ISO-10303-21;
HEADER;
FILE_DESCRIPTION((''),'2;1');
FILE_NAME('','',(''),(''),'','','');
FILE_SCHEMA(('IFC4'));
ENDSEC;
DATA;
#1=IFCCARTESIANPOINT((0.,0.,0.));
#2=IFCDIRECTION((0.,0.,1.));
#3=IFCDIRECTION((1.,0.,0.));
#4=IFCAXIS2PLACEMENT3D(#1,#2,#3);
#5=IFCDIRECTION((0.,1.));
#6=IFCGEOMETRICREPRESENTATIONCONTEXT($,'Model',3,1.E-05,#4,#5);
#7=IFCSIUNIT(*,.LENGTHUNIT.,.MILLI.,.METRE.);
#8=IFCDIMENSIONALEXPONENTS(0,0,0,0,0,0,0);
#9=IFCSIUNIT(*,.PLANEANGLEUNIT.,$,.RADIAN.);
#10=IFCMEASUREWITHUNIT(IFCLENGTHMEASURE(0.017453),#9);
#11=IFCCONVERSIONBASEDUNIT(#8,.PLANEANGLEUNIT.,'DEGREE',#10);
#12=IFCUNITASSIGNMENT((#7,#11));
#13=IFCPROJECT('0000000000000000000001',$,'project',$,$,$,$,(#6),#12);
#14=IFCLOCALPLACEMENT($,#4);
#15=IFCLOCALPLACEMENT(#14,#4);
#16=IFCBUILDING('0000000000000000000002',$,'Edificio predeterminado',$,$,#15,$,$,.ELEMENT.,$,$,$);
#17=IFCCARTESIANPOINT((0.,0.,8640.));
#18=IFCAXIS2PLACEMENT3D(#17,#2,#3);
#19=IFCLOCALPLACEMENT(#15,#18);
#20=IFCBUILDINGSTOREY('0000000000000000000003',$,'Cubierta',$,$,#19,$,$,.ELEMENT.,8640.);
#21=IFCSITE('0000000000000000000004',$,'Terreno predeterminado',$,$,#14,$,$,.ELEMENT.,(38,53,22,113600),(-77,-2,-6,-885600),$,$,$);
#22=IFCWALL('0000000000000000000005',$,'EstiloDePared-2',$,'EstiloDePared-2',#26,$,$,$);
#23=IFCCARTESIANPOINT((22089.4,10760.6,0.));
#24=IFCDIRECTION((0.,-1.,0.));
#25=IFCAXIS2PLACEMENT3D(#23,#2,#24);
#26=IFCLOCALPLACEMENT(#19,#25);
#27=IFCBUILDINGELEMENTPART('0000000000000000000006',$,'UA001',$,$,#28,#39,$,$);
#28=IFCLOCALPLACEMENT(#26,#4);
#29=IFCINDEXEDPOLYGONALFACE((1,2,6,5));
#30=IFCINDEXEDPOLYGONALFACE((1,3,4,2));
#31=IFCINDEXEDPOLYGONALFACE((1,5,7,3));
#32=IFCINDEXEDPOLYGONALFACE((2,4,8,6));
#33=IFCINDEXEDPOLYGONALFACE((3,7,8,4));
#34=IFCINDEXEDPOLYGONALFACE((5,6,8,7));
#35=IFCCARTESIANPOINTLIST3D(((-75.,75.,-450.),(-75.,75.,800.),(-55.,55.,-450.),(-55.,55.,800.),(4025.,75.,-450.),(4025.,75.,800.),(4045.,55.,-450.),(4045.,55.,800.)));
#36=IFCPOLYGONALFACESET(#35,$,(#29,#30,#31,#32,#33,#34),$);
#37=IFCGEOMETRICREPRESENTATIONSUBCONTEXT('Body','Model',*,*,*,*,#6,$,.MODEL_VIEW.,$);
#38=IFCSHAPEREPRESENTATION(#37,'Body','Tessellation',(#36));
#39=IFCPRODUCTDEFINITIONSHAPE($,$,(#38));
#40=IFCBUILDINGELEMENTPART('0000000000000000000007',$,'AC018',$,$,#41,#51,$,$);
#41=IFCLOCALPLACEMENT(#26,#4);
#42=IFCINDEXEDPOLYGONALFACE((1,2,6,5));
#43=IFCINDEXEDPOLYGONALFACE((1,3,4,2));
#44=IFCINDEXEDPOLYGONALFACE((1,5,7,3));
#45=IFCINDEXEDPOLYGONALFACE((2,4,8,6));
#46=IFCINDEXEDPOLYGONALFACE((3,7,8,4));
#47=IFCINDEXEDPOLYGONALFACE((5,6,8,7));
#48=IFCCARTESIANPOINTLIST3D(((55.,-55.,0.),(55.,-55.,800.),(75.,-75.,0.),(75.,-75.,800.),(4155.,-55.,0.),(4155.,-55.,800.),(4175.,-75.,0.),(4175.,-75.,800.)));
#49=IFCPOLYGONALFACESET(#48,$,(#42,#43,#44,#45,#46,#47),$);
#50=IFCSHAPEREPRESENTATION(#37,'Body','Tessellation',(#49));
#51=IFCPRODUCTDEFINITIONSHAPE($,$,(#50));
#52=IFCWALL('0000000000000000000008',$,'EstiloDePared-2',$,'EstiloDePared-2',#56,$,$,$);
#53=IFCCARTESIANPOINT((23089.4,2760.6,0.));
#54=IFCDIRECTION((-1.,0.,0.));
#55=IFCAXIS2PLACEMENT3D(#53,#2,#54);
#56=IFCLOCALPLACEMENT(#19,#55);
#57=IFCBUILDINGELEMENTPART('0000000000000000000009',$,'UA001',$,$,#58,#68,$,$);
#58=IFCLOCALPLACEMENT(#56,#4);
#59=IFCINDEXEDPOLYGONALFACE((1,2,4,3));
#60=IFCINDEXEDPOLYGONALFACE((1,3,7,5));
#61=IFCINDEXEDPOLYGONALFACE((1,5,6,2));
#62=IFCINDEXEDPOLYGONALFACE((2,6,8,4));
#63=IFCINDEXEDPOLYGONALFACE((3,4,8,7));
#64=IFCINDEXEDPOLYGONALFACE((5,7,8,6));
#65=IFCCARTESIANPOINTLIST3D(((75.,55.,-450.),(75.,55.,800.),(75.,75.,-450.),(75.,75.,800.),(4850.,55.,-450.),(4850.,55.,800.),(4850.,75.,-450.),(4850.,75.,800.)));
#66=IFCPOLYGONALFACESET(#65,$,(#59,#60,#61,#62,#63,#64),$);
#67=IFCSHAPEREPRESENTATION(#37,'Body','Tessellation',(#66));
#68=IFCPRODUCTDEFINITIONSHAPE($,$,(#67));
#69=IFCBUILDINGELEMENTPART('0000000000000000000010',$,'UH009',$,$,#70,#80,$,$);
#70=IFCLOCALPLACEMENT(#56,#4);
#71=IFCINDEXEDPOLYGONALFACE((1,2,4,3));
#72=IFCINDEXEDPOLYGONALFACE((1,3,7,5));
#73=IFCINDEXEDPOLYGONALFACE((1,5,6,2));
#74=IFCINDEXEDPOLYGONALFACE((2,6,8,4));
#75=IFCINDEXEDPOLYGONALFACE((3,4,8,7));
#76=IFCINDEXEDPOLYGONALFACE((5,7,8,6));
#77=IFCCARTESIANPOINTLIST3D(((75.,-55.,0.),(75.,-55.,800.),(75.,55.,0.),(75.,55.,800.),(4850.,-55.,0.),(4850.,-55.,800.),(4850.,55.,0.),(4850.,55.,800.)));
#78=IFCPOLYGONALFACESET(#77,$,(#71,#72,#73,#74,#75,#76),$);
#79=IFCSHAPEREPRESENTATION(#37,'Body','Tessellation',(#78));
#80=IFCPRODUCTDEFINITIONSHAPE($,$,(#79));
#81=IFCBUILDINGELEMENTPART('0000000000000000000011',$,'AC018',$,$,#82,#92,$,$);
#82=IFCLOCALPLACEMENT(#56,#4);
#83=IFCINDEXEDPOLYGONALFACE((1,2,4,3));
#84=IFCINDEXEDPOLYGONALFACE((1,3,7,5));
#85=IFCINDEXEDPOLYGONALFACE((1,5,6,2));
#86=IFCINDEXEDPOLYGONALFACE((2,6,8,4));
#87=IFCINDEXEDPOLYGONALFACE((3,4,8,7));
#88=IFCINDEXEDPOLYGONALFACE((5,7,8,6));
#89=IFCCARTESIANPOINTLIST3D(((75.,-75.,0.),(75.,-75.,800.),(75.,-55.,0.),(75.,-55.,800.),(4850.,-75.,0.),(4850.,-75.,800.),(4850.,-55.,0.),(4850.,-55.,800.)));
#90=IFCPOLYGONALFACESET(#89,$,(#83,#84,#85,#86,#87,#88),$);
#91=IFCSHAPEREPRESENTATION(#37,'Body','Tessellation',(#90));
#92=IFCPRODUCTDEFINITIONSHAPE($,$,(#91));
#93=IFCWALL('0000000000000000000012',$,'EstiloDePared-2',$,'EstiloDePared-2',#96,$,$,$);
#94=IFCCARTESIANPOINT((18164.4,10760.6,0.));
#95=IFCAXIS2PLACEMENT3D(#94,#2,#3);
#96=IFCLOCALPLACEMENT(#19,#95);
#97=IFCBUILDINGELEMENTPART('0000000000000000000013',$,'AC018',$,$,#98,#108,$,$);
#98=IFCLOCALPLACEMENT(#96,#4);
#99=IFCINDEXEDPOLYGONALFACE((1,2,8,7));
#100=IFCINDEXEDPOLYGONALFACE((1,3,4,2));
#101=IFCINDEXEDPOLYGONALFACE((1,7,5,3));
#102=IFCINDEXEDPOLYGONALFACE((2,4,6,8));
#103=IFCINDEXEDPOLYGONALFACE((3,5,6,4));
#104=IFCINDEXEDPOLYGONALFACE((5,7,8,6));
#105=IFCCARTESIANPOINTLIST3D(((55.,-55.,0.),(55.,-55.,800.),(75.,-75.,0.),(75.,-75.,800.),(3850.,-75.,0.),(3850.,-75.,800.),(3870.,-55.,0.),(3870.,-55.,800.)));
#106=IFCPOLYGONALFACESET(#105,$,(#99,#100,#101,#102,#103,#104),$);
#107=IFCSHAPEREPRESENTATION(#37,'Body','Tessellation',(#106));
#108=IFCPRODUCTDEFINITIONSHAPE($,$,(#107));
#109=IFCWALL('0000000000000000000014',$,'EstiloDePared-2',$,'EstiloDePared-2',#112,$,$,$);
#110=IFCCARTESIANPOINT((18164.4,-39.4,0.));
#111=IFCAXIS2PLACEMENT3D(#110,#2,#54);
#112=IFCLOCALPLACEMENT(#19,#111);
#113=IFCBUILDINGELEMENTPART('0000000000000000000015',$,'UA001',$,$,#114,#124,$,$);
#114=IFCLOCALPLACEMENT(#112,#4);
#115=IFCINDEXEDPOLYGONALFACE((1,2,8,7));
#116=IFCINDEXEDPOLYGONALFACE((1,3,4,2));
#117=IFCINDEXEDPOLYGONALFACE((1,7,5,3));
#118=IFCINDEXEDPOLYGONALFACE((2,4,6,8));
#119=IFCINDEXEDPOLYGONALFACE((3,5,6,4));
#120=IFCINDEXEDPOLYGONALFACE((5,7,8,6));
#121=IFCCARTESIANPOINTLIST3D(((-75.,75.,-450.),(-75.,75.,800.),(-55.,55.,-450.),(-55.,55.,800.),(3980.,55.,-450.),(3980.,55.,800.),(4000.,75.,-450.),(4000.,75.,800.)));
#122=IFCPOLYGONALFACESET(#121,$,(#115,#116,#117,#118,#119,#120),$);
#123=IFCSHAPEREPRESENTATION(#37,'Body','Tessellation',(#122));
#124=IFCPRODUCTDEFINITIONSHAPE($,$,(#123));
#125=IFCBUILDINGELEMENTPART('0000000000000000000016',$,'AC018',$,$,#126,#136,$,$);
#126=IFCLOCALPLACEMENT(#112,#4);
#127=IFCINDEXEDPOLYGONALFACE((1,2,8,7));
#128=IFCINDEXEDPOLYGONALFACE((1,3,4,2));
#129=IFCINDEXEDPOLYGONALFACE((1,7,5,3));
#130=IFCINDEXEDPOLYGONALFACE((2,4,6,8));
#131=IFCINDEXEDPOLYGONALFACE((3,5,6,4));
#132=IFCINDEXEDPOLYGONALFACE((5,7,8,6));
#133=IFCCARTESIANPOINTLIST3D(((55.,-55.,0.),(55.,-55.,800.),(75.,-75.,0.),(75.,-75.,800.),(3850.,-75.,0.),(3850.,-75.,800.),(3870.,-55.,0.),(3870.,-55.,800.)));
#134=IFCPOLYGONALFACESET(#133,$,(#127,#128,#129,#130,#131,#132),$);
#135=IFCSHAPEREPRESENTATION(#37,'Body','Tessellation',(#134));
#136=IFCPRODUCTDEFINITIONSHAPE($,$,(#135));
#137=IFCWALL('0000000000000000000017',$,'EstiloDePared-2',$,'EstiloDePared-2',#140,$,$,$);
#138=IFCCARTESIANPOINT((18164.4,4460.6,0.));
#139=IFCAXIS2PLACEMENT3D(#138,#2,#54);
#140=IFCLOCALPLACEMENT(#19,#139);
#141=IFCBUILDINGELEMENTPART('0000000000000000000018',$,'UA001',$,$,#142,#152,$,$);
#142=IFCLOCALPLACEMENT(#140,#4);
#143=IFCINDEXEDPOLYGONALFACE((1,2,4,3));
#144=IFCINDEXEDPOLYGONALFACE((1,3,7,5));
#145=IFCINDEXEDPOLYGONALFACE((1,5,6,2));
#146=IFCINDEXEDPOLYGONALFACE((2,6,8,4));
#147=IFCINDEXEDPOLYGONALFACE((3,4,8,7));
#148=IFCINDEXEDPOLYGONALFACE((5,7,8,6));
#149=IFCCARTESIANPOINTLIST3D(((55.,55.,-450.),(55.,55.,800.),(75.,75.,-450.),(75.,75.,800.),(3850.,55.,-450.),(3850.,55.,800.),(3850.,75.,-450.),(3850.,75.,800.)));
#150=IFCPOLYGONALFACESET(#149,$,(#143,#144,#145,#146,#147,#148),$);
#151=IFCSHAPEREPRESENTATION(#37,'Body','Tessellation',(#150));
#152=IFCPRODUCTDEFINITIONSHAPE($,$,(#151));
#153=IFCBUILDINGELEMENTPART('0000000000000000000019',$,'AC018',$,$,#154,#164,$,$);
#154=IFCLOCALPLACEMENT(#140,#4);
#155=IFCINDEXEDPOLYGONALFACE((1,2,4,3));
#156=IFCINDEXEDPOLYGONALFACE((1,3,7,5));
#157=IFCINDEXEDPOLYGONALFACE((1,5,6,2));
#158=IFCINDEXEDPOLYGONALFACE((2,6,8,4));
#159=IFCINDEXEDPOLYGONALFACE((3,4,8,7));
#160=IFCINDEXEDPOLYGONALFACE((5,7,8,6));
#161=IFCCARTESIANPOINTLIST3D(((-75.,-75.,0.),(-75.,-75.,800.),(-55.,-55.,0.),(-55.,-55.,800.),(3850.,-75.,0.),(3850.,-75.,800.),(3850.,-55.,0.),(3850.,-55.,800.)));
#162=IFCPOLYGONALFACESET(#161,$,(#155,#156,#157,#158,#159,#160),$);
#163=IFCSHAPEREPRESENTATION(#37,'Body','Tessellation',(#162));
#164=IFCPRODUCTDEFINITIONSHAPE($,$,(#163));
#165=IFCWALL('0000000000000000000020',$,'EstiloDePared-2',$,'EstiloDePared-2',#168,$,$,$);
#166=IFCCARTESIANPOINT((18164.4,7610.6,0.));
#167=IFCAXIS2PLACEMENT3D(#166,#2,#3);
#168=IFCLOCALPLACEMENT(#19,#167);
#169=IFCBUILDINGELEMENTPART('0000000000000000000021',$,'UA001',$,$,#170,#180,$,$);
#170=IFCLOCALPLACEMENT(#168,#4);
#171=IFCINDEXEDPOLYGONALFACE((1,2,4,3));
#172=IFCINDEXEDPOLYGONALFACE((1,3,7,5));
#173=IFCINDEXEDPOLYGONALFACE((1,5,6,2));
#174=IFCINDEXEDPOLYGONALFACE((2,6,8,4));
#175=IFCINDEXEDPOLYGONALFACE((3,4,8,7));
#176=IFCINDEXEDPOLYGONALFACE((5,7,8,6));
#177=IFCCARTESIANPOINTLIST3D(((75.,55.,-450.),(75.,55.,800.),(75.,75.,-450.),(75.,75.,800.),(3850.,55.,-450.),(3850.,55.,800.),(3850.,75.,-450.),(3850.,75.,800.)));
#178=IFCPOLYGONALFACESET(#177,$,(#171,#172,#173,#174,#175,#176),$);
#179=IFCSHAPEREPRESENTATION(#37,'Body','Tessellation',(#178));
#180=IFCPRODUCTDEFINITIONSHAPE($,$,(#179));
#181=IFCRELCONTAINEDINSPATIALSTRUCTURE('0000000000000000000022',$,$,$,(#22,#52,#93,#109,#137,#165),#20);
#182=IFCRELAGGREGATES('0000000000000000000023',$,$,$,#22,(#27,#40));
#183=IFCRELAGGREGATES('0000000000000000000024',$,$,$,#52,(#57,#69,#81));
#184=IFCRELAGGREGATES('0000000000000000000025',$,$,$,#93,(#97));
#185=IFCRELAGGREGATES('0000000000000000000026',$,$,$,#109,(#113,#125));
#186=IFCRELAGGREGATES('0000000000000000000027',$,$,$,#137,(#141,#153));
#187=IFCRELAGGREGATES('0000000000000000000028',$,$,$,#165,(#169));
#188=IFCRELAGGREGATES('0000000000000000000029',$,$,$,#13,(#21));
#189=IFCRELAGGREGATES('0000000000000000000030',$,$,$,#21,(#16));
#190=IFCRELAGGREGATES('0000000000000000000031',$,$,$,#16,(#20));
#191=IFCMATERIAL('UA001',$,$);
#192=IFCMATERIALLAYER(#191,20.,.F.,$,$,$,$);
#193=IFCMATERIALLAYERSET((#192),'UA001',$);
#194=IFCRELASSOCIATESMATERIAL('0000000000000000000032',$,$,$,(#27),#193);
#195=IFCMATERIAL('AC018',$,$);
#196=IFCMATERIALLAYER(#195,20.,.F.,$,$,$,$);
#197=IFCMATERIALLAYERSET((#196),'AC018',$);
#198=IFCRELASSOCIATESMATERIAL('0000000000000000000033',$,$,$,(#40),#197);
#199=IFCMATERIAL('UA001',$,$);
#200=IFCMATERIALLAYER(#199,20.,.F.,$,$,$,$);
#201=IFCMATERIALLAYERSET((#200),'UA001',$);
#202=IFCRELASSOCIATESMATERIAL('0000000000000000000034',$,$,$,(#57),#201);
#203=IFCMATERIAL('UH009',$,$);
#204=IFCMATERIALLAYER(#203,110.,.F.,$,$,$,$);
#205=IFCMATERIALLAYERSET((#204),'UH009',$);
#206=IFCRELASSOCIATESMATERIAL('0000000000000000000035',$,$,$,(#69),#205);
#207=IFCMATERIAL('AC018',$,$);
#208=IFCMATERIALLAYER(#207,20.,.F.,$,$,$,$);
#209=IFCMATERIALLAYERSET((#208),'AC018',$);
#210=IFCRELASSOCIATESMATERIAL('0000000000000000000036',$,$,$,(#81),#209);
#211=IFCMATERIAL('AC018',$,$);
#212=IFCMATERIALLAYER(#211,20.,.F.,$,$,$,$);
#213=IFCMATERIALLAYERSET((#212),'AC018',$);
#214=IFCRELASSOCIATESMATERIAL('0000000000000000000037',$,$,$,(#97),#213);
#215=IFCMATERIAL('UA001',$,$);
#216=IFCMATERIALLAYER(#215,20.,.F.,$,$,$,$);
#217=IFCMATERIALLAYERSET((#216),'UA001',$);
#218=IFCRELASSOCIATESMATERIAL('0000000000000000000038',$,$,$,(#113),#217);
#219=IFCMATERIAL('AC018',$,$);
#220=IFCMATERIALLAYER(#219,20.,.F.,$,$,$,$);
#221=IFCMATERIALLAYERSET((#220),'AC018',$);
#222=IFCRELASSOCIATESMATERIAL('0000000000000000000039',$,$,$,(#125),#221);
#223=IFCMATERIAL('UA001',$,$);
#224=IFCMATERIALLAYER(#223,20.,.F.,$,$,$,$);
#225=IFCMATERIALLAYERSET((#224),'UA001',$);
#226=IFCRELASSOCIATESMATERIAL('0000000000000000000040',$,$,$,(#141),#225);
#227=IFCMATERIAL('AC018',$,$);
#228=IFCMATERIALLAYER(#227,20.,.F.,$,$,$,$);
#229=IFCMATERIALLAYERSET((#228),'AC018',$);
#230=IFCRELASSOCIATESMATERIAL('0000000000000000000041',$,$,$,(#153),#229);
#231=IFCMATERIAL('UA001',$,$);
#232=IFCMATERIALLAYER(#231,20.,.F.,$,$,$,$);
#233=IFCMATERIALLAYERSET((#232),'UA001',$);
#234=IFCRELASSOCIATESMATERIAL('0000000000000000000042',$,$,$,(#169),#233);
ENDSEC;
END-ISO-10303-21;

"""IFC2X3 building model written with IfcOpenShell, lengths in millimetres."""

from ifc_helpers import new_model, entity, si_unit, converted_unit, direction, frame, origin_with_axes, place, context, subcontext, project, spatial, polyline, outline, extrude, material, layer, layer_set, layer_usage, element, aggregate, save


model = new_model("IFC2X3")

# Units and contexts
model_context = context("Model", 3, precision=1e-05, world=origin_with_axes(), true_north=direction((0.0, 1.0)))
body_context = subcontext(model_context, "Body", "Model", "MODEL_VIEW")
ifc_project = project(units=[si_unit("LENGTHUNIT", "METRE", prefix="MILLI"), converted_unit("PLANEANGLEUNIT", "DEGREE", entity("IfcLengthMeasure", 0.017453), si_unit("PLANEANGLEUNIT", "RADIAN"), dimensions=[0, 0, 0, 0, 0, 0, 0])], contexts=[model_context])

# Site, building, storey
site_placement = place(None, origin_with_axes())
site = spatial("IfcSite", under=ifc_project, at=site_placement, Name="Terreno predeterminado", CompositionType="ELEMENT", RefLatitude=(38, 53, 22, 113600), RefLongitude=(-77, -2, -6, -885600))
building_placement = place(site_placement, origin_with_axes())
building = spatial("IfcBuilding", under=site, at=building_placement, Name="Edificio predeterminado", CompositionType="ELEMENT")
storey_placement = place(building_placement, frame((0.0, 0.0, 8640.0), z_axis=(0.0, 0.0, 1.0), x_axis=(1.0, 0.0, 0.0)))
storey = spatial("IfcBuildingStorey", under=building, at=storey_placement, Name="Cubierta", CompositionType="ELEMENT", Elevation=8640.0)

# Walls, building element parts
wall_1_placement = place(storey_placement, frame((22089.4, 10760.6, 0.0), z_axis=(0.0, 0.0, 1.0), x_axis=(0.0, -1.0, 0.0)))
wall_1 = element("IfcWall", 1, at=wall_1_placement, inside=storey, Name="EstiloDePared-2", ObjectType="EstiloDePared-2")
ifc_material_1 = material(Name="UA001")
ifc_layer_1 = layer(ifc_material_1, 20.0, ventilated=False)
ifc_layer_set_1 = layer_set([ifc_layer_1], Name="UA001")
ifc_layer_usage_1 = layer_usage(ifc_layer_set_1, "AXIS2", "NEGATIVE", -75.0)
building_element_part_1_placement = place(wall_1_placement, origin_with_axes())
building_element_part_1 = element("IfcBuildingElementPart", 2, at=building_element_part_1_placement, material=ifc_layer_usage_1, Name="UA001", context=body_context, shape_type="SweptSolid", body=[
    extrude(outline(polyline([(4025.0, 75.0), (4045.0, 55.0), (-55.0, 55.0), (-75.0, 75.0), (4025.0, 75.0)])), frame((0.0, 0.0, -450.0), z_axis=(0.0, 0.0, 1.0), x_axis=(1.0, 0.0, 0.0)), (0.0, 0.0, 1.0), 1250.0),
])
ifc_material_2 = material(Name="AC018")
ifc_layer_2 = layer(ifc_material_2, 20.0, ventilated=False)
ifc_layer_set_2 = layer_set([ifc_layer_2], Name="AC018")
ifc_layer_usage_2 = layer_usage(ifc_layer_set_2, "AXIS2", "NEGATIVE", 55.0)
building_element_part_2_placement = place(wall_1_placement, origin_with_axes())
building_element_part_2 = element("IfcBuildingElementPart", 3, at=building_element_part_2_placement, material=ifc_layer_usage_2, Name="AC018", context=body_context, shape_type="SweptSolid", body=[
    extrude(outline(polyline([(4155.0, -55.0), (4175.0, -75.0), (75.0, -75.0), (55.0, -55.0), (4155.0, -55.0)])), origin_with_axes(), (0.0, 0.0, 1.0), 800.0),
])
aggregate(wall_1, [building_element_part_1, building_element_part_2])
wall_2_placement = place(storey_placement, frame((23089.4, 2760.6, 0.0), z_axis=(0.0, 0.0, 1.0), x_axis=(-1.0, 0.0, 0.0)))
wall_2 = element("IfcWall", 4, at=wall_2_placement, inside=storey, Name="EstiloDePared-2", ObjectType="EstiloDePared-2")
ifc_material_3 = material(Name="UA001")
ifc_layer_3 = layer(ifc_material_3, 20.0, ventilated=False)
ifc_layer_set_3 = layer_set([ifc_layer_3], Name="UA001")
ifc_layer_usage_3 = layer_usage(ifc_layer_set_3, "AXIS2", "NEGATIVE", -75.0)
building_element_part_3_placement = place(wall_2_placement, origin_with_axes())
building_element_part_3 = element("IfcBuildingElementPart", 5, at=building_element_part_3_placement, material=ifc_layer_usage_3, Name="UA001", context=body_context, shape_type="SweptSolid", body=[
    extrude(outline(polyline([(4850.0, 75.0), (4850.0, 55.0), (75.0, 55.0), (75.0, 75.0), (4850.0, 75.0)])), frame((0.0, 0.0, -450.0), z_axis=(0.0, 0.0, 1.0), x_axis=(1.0, 0.0, 0.0)), (0.0, 0.0, 1.0), 1250.0),
])
ifc_material_4 = material(Name="UH009")
ifc_layer_4 = layer(ifc_material_4, 110.0, ventilated=False)
ifc_layer_set_4 = layer_set([ifc_layer_4], Name="UH009")
ifc_layer_usage_4 = layer_usage(ifc_layer_set_4, "AXIS2", "NEGATIVE", -55.0)
building_element_part_4_placement = place(wall_2_placement, origin_with_axes())
building_element_part_4 = element("IfcBuildingElementPart", 6, at=building_element_part_4_placement, material=ifc_layer_usage_4, Name="UH009", context=body_context, shape_type="SweptSolid", body=[
    extrude(outline(polyline([(4850.0, 55.0), (4850.0, -55.0), (75.0, -55.0), (75.0, 55.0), (4850.0, 55.0)])), origin_with_axes(), (0.0, 0.0, 1.0), 800.0),
])
ifc_material_5 = material(Name="AC018")
ifc_layer_5 = layer(ifc_material_5, 20.0, ventilated=False)
ifc_layer_set_5 = layer_set([ifc_layer_5], Name="AC018")
ifc_layer_usage_5 = layer_usage(ifc_layer_set_5, "AXIS2", "NEGATIVE", 55.0)
building_element_part_5_placement = place(wall_2_placement, origin_with_axes())
building_element_part_5 = element("IfcBuildingElementPart", 7, at=building_element_part_5_placement, material=ifc_layer_usage_5, Name="AC018", context=body_context, shape_type="SweptSolid", body=[
    extrude(outline(polyline([(4850.0, -55.0), (4850.0, -75.0), (75.0, -75.0), (75.0, -55.0), (4850.0, -55.0)])), origin_with_axes(), (0.0, 0.0, 1.0), 800.0),
])
aggregate(wall_2, [building_element_part_3, building_element_part_4, building_element_part_5])

# Wall, building element part
wall_3_placement = place(storey_placement, frame((18164.4, 10760.6, 0.0), z_axis=(0.0, 0.0, 1.0), x_axis=(1.0, 0.0, 0.0)))
wall_3 = element("IfcWall", 8, at=wall_3_placement, inside=storey, Name="EstiloDePared-2", ObjectType="EstiloDePared-2")
ifc_material_6 = material(Name="AC018")
ifc_layer_6 = layer(ifc_material_6, 20.0, ventilated=False)
ifc_layer_set_6 = layer_set([ifc_layer_6], Name="AC018")
ifc_layer_usage_6 = layer_usage(ifc_layer_set_6, "AXIS2", "NEGATIVE", 55.0)
building_element_part_6_placement = place(wall_3_placement, origin_with_axes())
building_element_part_6 = element("IfcBuildingElementPart", 9, at=building_element_part_6_placement, material=ifc_layer_usage_6, Name="AC018", context=body_context, shape_type="SweptSolid", body=[
    extrude(outline(polyline([(3870.0, -55.0), (3850.0, -75.0), (75.0, -75.0), (55.0, -55.0), (3870.0, -55.0)])), origin_with_axes(), (0.0, 0.0, 1.0), 800.0),
])
aggregate(wall_3, [building_element_part_6])

# Walls, building element parts
wall_4_placement = place(storey_placement, frame((18164.4, -39.4, 0.0), z_axis=(0.0, 0.0, 1.0), x_axis=(-1.0, 0.0, 0.0)))
wall_4 = element("IfcWall", 10, at=wall_4_placement, inside=storey, Name="EstiloDePared-2", ObjectType="EstiloDePared-2")
ifc_material_7 = material(Name="UA001")
ifc_layer_7 = layer(ifc_material_7, 20.0, ventilated=False)
ifc_layer_set_7 = layer_set([ifc_layer_7], Name="UA001")
ifc_layer_usage_7 = layer_usage(ifc_layer_set_7, "AXIS2", "NEGATIVE", -75.0)
building_element_part_7_placement = place(wall_4_placement, origin_with_axes())
building_element_part_7 = element("IfcBuildingElementPart", 11, at=building_element_part_7_placement, material=ifc_layer_usage_7, Name="UA001", context=body_context, shape_type="SweptSolid", body=[
    extrude(outline(polyline([(4000.0, 75.0), (3980.0, 55.0), (-55.0, 55.0), (-75.0, 75.0), (4000.0, 75.0)])), frame((0.0, 0.0, -450.0), z_axis=(0.0, 0.0, 1.0), x_axis=(1.0, 0.0, 0.0)), (0.0, 0.0, 1.0), 1250.0),
])
ifc_material_8 = material(Name="AC018")
ifc_layer_8 = layer(ifc_material_8, 20.0, ventilated=False)
ifc_layer_set_8 = layer_set([ifc_layer_8], Name="AC018")
ifc_layer_usage_8 = layer_usage(ifc_layer_set_8, "AXIS2", "NEGATIVE", 55.0)
building_element_part_8_placement = place(wall_4_placement, origin_with_axes())
building_element_part_8 = element("IfcBuildingElementPart", 12, at=building_element_part_8_placement, material=ifc_layer_usage_8, Name="AC018", context=body_context, shape_type="SweptSolid", body=[
    extrude(outline(polyline([(3870.0, -55.0), (3850.0, -75.0), (75.0, -75.0), (55.0, -55.0), (3870.0, -55.0)])), origin_with_axes(), (0.0, 0.0, 1.0), 800.0),
])
aggregate(wall_4, [building_element_part_7, building_element_part_8])
wall_5_placement = place(storey_placement, frame((18164.4, 4460.6, 0.0), z_axis=(0.0, 0.0, 1.0), x_axis=(-1.0, 0.0, 0.0)))
wall_5 = element("IfcWall", 13, at=wall_5_placement, inside=storey, Name="EstiloDePared-2", ObjectType="EstiloDePared-2")
ifc_material_9 = material(Name="UA001")
ifc_layer_9 = layer(ifc_material_9, 20.0, ventilated=False)
ifc_layer_set_9 = layer_set([ifc_layer_9], Name="UA001")
ifc_layer_usage_9 = layer_usage(ifc_layer_set_9, "AXIS2", "NEGATIVE", -75.0)
building_element_part_9_placement = place(wall_5_placement, origin_with_axes())
building_element_part_9 = element("IfcBuildingElementPart", 14, at=building_element_part_9_placement, material=ifc_layer_usage_9, Name="UA001", context=body_context, shape_type="SweptSolid", body=[
    extrude(outline(polyline([(3850.0, 75.0), (3850.0, 55.0), (55.0, 55.0), (75.0, 75.0), (3850.0, 75.0)])), frame((0.0, 0.0, -450.0), z_axis=(0.0, 0.0, 1.0), x_axis=(1.0, 0.0, 0.0)), (0.0, 0.0, 1.0), 1250.0),
])
ifc_material_10 = material(Name="AC018")
ifc_layer_10 = layer(ifc_material_10, 20.0, ventilated=False)
ifc_layer_set_10 = layer_set([ifc_layer_10], Name="AC018")
ifc_layer_usage_10 = layer_usage(ifc_layer_set_10, "AXIS2", "NEGATIVE", 55.0)
building_element_part_10_placement = place(wall_5_placement, origin_with_axes())
building_element_part_10 = element("IfcBuildingElementPart", 15, at=building_element_part_10_placement, material=ifc_layer_usage_10, Name="AC018", context=body_context, shape_type="SweptSolid", body=[
    extrude(outline(polyline([(3850.0, -55.0), (3850.0, -75.0), (-75.0, -75.0), (-55.0, -55.0), (3850.0, -55.0)])), origin_with_axes(), (0.0, 0.0, 1.0), 800.0),
])
aggregate(wall_5, [building_element_part_9, building_element_part_10])
wall_6_placement = place(storey_placement, frame((18164.4, 7610.6, 0.0), z_axis=(0.0, 0.0, 1.0), x_axis=(1.0, 0.0, 0.0)))
wall_6 = element("IfcWall", 16, at=wall_6_placement, inside=storey, Name="EstiloDePared-2", ObjectType="EstiloDePared-2")
ifc_material_11 = material(Name="UA001")
ifc_layer_11 = layer(ifc_material_11, 20.0, ventilated=False)
ifc_layer_set_11 = layer_set([ifc_layer_11], Name="UA001")
ifc_layer_usage_11 = layer_usage(ifc_layer_set_11, "AXIS2", "NEGATIVE", -75.0)
building_element_part_11_placement = place(wall_6_placement, origin_with_axes())
building_element_part_11 = element("IfcBuildingElementPart", 17, at=building_element_part_11_placement, material=ifc_layer_usage_11, Name="UA001", context=body_context, shape_type="SweptSolid", body=[
    extrude(outline(polyline([(3850.0, 75.0), (3850.0, 55.0), (75.0, 55.0), (75.0, 75.0), (3850.0, 75.0)])), frame((0.0, 0.0, -450.0), z_axis=(0.0, 0.0, 1.0), x_axis=(1.0, 0.0, 0.0)), (0.0, 0.0, 1.0), 1250.0),
])
aggregate(wall_6, [building_element_part_11])

save(model, "model.ifc")
